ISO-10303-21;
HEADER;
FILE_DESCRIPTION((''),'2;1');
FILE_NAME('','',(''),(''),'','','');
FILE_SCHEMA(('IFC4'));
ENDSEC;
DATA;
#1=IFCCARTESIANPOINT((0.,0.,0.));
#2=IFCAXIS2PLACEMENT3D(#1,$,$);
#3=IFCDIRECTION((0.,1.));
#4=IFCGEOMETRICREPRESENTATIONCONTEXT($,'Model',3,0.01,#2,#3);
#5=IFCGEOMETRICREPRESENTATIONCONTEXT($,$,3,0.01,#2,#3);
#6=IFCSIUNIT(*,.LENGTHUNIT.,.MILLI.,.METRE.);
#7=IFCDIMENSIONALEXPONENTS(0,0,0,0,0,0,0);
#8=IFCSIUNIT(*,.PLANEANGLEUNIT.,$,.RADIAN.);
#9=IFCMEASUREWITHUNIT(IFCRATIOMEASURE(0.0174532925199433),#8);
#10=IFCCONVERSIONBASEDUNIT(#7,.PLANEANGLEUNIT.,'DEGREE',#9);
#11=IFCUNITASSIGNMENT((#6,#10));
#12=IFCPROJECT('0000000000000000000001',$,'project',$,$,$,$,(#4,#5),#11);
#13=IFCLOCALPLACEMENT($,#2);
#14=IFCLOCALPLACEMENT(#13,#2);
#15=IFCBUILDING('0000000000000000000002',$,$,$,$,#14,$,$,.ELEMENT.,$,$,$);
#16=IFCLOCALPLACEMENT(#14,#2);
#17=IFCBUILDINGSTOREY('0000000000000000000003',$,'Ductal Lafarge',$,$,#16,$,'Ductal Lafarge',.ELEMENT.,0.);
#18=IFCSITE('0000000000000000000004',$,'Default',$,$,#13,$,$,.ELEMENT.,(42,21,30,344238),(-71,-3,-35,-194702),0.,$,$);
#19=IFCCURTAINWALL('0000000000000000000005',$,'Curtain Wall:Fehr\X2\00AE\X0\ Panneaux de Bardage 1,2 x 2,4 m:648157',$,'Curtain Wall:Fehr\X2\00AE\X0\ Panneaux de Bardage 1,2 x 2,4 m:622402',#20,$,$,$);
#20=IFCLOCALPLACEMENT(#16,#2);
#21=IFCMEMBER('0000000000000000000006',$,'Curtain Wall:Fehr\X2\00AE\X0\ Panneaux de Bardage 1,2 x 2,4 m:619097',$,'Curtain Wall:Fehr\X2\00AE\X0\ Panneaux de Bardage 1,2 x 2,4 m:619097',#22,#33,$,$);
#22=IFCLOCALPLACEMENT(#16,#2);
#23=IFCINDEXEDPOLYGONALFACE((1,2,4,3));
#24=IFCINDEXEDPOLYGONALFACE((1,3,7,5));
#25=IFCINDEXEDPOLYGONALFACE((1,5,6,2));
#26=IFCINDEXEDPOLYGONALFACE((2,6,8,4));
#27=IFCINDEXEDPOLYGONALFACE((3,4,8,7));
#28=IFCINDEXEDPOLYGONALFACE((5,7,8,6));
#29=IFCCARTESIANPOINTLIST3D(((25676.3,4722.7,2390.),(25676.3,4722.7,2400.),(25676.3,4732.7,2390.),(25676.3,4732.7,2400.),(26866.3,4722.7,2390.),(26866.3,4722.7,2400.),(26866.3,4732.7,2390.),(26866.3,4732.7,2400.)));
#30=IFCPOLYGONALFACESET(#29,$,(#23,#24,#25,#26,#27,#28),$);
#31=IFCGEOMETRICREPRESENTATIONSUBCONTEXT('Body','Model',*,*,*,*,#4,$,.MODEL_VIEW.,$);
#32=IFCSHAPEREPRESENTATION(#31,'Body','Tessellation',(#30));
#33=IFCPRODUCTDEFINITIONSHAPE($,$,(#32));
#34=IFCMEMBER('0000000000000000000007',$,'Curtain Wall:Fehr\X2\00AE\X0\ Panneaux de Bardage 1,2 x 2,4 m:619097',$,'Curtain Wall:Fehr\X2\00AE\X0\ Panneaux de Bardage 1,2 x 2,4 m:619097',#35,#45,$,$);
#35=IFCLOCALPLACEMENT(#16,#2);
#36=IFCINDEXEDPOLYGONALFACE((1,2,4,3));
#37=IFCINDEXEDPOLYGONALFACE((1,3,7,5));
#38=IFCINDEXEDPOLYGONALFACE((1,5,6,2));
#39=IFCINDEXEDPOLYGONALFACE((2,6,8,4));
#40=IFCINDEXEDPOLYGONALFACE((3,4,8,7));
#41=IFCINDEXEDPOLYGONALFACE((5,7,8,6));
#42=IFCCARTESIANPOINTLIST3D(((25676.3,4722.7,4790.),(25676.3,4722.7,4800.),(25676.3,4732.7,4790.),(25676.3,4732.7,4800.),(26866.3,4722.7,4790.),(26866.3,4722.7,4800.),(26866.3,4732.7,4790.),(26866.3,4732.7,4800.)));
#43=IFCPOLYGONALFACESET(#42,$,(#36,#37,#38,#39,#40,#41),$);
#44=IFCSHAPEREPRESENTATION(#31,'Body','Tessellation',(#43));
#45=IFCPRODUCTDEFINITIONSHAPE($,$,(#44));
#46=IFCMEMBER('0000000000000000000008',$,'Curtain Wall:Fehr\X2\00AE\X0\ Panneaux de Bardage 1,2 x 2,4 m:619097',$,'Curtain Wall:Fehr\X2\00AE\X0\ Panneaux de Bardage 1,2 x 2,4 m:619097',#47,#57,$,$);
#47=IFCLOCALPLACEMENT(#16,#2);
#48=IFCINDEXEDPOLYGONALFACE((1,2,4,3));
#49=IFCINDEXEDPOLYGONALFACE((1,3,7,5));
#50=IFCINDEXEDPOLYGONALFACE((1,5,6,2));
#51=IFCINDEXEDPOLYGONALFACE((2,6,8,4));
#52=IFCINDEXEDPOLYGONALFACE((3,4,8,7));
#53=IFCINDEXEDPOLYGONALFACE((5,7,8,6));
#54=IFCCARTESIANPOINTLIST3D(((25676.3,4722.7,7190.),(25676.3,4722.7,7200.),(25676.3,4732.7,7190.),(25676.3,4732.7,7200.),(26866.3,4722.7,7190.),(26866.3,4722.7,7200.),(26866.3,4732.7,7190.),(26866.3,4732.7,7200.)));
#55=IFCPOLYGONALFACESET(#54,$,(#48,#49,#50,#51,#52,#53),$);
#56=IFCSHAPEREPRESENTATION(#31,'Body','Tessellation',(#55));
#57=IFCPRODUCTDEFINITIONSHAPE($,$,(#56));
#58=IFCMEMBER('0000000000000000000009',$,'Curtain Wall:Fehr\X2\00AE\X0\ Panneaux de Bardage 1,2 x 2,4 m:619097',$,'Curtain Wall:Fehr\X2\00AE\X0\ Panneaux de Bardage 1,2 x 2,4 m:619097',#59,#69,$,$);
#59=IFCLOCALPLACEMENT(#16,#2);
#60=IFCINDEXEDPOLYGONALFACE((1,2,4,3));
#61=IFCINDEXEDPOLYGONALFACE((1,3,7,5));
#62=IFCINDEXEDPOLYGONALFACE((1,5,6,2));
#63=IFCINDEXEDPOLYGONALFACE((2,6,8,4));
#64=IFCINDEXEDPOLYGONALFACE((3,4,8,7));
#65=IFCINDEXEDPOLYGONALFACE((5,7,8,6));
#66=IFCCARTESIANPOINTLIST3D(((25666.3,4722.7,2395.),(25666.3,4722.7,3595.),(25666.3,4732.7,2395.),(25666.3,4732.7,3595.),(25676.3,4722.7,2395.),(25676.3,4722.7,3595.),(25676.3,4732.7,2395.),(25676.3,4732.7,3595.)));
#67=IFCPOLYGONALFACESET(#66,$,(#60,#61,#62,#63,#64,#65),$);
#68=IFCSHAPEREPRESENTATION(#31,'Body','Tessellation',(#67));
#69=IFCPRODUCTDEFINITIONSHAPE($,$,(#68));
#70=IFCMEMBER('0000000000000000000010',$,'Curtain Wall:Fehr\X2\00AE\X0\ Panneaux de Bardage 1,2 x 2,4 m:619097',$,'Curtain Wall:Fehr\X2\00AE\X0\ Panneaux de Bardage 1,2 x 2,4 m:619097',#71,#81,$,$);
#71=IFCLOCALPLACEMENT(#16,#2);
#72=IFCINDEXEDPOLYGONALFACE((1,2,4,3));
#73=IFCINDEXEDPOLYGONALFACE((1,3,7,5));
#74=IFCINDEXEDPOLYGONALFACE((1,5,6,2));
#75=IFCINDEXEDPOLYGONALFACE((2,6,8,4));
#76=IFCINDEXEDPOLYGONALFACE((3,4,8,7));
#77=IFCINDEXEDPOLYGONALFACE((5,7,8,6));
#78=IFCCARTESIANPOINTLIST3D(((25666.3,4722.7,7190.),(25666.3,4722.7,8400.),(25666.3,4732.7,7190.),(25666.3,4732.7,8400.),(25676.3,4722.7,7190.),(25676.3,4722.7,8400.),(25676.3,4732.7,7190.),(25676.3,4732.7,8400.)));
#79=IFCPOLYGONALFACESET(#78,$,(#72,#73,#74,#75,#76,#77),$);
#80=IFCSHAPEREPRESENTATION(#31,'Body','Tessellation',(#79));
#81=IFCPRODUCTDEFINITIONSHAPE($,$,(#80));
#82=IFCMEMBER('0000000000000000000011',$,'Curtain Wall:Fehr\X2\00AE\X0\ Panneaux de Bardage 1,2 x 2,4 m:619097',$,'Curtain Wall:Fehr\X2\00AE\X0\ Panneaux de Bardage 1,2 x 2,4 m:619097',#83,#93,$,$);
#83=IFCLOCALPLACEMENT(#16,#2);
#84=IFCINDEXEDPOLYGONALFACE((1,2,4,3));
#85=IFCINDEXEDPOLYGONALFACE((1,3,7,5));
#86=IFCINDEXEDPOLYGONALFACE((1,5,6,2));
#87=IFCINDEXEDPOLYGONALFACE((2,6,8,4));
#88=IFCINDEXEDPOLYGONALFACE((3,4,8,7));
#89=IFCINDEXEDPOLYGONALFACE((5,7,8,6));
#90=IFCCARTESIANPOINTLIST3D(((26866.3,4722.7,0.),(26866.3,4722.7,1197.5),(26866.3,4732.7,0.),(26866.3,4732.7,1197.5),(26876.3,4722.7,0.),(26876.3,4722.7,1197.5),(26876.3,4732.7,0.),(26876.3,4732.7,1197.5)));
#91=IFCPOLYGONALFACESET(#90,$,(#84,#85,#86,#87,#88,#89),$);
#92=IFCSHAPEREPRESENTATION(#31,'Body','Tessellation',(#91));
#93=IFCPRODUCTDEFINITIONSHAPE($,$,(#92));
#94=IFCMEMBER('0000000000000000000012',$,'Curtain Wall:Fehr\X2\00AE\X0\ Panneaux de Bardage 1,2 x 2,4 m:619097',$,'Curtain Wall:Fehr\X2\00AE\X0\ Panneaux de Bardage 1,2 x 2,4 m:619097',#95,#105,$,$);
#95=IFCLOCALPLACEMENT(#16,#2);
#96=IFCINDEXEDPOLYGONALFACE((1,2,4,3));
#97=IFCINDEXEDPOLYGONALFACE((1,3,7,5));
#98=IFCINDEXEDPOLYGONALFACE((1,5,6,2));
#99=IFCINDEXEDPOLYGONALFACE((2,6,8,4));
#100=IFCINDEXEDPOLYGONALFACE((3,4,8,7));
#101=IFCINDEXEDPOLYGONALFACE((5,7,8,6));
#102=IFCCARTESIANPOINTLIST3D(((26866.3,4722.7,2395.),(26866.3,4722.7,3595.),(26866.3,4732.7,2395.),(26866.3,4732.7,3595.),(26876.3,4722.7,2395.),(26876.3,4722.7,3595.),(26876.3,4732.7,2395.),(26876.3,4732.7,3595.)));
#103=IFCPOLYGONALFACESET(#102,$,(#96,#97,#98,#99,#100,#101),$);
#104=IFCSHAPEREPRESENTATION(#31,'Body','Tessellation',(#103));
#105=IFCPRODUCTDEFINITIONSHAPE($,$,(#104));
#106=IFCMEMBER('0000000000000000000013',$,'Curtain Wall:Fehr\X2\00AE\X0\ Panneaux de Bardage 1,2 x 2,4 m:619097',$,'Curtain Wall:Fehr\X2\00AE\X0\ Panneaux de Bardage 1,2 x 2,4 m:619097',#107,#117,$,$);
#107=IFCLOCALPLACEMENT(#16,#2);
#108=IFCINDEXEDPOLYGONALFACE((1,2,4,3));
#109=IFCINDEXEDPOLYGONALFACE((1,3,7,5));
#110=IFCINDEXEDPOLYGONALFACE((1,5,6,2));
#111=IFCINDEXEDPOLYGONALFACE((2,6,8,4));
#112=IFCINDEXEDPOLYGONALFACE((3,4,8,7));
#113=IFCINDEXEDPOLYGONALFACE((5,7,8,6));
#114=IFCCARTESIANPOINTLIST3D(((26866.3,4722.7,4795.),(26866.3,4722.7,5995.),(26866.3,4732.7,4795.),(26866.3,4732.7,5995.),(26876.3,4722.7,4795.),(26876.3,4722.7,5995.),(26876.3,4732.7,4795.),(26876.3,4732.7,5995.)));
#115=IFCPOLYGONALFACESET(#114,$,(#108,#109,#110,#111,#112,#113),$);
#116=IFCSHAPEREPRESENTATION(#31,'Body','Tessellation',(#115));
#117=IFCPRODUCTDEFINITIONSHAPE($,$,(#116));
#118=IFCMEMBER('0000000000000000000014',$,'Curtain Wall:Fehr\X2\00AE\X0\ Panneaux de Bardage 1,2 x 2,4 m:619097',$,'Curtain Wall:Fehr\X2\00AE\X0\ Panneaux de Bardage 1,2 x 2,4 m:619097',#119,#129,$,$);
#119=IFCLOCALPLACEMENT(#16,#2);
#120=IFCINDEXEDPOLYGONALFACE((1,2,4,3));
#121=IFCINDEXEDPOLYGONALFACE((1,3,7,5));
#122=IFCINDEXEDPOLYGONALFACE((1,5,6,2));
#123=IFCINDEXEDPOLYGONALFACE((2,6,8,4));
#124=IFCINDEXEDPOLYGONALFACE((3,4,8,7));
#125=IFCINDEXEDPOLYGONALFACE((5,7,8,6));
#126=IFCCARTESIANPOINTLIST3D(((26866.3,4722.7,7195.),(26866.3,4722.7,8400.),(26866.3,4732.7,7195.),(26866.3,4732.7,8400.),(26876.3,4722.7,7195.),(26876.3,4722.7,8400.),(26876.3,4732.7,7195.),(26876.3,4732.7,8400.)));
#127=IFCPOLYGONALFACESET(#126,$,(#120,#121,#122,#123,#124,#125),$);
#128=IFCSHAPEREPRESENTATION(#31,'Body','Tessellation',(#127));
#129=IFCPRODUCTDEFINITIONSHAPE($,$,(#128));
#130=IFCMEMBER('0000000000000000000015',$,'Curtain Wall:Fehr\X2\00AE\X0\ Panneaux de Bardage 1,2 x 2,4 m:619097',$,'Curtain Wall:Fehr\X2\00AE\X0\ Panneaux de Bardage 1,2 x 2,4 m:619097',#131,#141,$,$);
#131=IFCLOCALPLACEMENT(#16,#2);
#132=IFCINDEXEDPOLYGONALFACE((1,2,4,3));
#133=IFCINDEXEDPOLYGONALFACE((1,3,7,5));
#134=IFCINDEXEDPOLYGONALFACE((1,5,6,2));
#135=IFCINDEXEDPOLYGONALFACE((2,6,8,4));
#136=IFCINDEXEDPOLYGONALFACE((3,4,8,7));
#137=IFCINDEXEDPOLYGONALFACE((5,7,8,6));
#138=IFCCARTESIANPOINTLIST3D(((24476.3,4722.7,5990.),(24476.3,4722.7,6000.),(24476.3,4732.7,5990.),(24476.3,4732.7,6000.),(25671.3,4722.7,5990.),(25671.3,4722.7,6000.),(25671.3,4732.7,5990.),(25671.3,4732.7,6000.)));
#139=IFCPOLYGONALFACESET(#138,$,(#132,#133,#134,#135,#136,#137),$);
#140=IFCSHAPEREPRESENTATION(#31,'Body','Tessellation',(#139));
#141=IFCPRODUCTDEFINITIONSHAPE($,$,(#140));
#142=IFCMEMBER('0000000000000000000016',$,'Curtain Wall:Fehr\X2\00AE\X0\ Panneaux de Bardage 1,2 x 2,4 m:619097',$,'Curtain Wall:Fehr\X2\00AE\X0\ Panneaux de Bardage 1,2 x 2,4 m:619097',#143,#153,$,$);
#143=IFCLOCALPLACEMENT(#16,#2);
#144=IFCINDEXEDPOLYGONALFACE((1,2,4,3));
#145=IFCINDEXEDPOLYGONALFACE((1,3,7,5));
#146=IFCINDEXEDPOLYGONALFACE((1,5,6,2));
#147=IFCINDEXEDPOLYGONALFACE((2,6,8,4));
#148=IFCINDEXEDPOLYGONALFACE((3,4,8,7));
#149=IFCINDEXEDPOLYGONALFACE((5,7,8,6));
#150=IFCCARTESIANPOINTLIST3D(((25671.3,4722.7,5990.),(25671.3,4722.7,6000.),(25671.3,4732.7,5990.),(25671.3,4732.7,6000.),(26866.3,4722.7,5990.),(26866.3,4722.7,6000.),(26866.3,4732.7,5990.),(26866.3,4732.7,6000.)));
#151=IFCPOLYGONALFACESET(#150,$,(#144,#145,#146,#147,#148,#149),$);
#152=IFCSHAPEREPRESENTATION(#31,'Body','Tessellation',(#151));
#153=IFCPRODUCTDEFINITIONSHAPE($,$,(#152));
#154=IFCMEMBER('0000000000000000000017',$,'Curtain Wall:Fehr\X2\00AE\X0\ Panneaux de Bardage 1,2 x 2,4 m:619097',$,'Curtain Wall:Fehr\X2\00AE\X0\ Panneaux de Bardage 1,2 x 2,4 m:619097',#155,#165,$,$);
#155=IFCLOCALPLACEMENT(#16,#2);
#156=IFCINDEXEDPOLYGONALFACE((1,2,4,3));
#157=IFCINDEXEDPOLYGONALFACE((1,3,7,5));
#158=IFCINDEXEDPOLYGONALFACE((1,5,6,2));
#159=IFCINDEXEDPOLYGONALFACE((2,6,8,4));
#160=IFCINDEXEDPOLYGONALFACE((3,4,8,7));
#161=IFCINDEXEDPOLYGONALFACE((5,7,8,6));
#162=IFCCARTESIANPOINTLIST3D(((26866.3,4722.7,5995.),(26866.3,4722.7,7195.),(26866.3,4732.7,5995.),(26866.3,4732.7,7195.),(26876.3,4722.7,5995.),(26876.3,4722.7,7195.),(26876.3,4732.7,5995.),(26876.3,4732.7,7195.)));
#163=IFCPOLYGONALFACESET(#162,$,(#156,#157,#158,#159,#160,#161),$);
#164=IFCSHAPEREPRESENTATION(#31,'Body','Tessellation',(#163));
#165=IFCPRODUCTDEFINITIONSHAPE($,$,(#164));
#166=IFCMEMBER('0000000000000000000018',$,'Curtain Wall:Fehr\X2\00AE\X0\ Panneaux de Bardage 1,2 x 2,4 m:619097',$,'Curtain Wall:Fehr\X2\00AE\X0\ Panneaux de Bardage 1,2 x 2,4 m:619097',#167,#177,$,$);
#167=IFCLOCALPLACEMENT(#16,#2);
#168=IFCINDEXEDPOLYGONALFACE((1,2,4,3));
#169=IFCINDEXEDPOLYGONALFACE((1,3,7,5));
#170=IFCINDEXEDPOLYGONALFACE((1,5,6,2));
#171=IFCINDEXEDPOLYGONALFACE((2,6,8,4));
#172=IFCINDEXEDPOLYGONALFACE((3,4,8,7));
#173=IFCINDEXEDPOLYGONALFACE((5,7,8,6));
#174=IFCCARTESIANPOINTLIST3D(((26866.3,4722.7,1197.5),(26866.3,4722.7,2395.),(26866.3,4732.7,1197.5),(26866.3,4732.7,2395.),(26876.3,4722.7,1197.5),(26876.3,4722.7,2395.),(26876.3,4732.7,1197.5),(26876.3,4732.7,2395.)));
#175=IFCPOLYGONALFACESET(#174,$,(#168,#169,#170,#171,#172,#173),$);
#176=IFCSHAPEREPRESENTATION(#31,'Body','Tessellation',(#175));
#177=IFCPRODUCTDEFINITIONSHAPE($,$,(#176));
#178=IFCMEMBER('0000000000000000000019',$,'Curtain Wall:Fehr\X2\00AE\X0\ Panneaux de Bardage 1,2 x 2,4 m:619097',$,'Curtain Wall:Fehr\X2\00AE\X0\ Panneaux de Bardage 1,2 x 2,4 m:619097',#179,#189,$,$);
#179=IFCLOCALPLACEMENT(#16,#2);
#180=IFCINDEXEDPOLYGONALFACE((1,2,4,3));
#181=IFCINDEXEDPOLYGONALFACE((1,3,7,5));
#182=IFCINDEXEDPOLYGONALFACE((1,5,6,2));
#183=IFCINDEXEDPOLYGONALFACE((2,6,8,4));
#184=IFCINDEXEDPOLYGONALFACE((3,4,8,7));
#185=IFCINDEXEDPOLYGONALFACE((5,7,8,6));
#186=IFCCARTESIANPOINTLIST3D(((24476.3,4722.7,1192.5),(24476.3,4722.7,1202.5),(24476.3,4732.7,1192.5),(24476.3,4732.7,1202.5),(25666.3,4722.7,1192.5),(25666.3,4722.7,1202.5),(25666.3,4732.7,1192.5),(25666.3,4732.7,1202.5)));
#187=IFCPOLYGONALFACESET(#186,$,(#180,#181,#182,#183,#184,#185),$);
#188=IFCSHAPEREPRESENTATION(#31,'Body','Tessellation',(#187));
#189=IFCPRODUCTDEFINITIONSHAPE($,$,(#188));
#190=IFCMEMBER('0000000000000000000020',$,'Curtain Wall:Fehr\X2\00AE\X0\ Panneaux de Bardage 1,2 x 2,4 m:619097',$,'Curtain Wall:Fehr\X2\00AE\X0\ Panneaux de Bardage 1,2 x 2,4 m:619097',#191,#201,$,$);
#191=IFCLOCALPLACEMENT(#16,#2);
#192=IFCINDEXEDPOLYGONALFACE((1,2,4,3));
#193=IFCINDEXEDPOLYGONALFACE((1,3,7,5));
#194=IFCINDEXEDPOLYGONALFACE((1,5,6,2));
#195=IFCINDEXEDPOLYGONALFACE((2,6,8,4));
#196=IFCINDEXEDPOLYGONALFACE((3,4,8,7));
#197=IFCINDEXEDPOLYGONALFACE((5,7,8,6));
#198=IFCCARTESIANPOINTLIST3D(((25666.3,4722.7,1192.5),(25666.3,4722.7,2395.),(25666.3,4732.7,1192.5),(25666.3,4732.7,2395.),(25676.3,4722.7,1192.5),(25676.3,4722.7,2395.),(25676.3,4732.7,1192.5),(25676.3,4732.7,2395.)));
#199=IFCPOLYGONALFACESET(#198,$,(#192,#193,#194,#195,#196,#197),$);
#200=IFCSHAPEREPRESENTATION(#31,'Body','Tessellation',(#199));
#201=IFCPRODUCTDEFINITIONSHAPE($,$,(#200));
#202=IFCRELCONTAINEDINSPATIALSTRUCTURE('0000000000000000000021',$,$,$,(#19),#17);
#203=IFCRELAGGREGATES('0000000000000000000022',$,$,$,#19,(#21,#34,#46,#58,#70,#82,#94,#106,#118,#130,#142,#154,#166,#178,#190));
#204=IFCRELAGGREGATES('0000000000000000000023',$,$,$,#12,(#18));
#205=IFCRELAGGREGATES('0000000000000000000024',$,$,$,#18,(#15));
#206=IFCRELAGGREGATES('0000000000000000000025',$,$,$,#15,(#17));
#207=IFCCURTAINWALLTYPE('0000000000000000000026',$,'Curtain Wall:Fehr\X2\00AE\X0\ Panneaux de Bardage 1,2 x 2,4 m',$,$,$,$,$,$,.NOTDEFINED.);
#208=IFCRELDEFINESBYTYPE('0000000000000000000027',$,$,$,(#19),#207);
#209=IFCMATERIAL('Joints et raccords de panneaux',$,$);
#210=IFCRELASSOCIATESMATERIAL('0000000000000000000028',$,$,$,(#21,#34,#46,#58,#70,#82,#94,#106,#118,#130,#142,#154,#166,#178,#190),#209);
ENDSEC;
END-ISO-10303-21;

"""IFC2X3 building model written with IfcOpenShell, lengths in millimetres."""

from ifc_helpers import new_model, entity, si_unit, converted_unit, direction, frame, frame_2d, origin, origin_2d_with_axis, place, context, subcontext, project, spatial, rectangle, extrude, material, type_object, element, aggregate, save


model = new_model("IFC2X3")

# Units and contexts
model_context = context("Model", 3, precision=0.01, world=origin(), true_north=direction((0.0, 1.0)))
context_of_model = context(None, 3, precision=0.01, world=origin(), true_north=direction((0.0, 1.0)))
body_context = subcontext(model_context, "Body", "Model", "MODEL_VIEW")
ifc_project = project(units=[si_unit("LENGTHUNIT", "METRE", prefix="MILLI"), converted_unit("PLANEANGLEUNIT", "DEGREE", entity("IfcRatioMeasure", 0.0174532925199433), si_unit("PLANEANGLEUNIT", "RADIAN"), dimensions=[0, 0, 0, 0, 0, 0, 0])], contexts=[model_context, context_of_model])

# Site, building, storey
site_placement = place(None, origin())
site = spatial("IfcSite", under=ifc_project, at=site_placement, Name="Default", CompositionType="ELEMENT", RefLatitude=(42, 21, 30, 344238), RefLongitude=(-71, -3, -35, -194702), RefElevation=0.0)
building_placement = place(site_placement, origin())
building = spatial("IfcBuilding", under=site, at=building_placement, CompositionType="ELEMENT")
storey_placement = place(building_placement, origin())
storey = spatial("IfcBuildingStorey", under=building, at=storey_placement, Name="Ductal Lafarge", LongName="Ductal Lafarge", CompositionType="ELEMENT", Elevation=0.0)

# Curtain wall, members
curtain_wall_type = type_object("IfcCurtainWallType", Name="Curtain Wall:Fehr® Panneaux de Bardage 1,2 x 2,4 m", PredefinedType="NOTDEFINED")
curtain_wall_placement = place(storey_placement, origin())
curtain_wall = element("IfcCurtainWall", 1, at=curtain_wall_placement, inside=storey, type_object=curtain_wall_type, Name="Curtain Wall:Fehr® Panneaux de Bardage 1,2 x 2,4 m:648157", ObjectType="Curtain Wall:Fehr® Panneaux de Bardage 1,2 x 2,4 m:622402")
ifc_material_1 = material(Name="Joints et raccords de panneaux")
member_1_placement = place(curtain_wall_placement, frame((25676.3, 4722.7, 2390.0)))
member_1 = element("IfcMember", 2, at=member_1_placement, material=ifc_material_1, Name="Curtain Wall:Fehr® Panneaux de Bardage 1,2 x 2,4 m:619097", ObjectType="Curtain Wall:Fehr® Panneaux de Bardage 1,2 x 2,4 m:619097", context=body_context, shape_type="SweptSolid", body=[
    extrude(rectangle(XDim=1190.0, YDim=10.0, at=frame_2d((0.0, 0.0), x_axis=(1.0, 0.0))), frame((595.0, 5.0, 0.0), z_axis=(0.0, 0.0, 1.0), x_axis=(-1.0, 0.0, 0.0)), (0.0, 0.0, 1.0), 10.0),
])
member_2_placement = place(curtain_wall_placement, frame((25676.3, 4722.7, 4790.0)))
member_2 = element("IfcMember", 3, at=member_2_placement, material=ifc_material_1, Name="Curtain Wall:Fehr® Panneaux de Bardage 1,2 x 2,4 m:619097", ObjectType="Curtain Wall:Fehr® Panneaux de Bardage 1,2 x 2,4 m:619097", context=body_context, shape_type="SweptSolid", body=[
    extrude(rectangle(XDim=1190.0, YDim=10.0, at=frame_2d((0.0, 0.0), x_axis=(1.0, 0.0))), frame((595.0, 5.0, 0.0), z_axis=(0.0, 0.0, 1.0), x_axis=(-1.0, 0.0, 0.0)), (0.0, 0.0, 1.0), 10.0),
])
member_3_placement = place(curtain_wall_placement, frame((25676.3, 4722.7, 7190.0)))
member_3 = element("IfcMember", 4, at=member_3_placement, material=ifc_material_1, Name="Curtain Wall:Fehr® Panneaux de Bardage 1,2 x 2,4 m:619097", ObjectType="Curtain Wall:Fehr® Panneaux de Bardage 1,2 x 2,4 m:619097", context=body_context, shape_type="SweptSolid", body=[
    extrude(rectangle(XDim=1190.0, YDim=10.0, at=frame_2d((0.0, 0.0), x_axis=(1.0, 0.0))), frame((595.0, 5.0, 0.0), z_axis=(0.0, 0.0, 1.0), x_axis=(-1.0, 0.0, 0.0)), (0.0, 0.0, 1.0), 10.0),
])
member_4_placement = place(curtain_wall_placement, frame((25666.3, 4722.7, 2395.0)))
member_4 = element("IfcMember", 5, at=member_4_placement, material=ifc_material_1, Name="Curtain Wall:Fehr® Panneaux de Bardage 1,2 x 2,4 m:619097", ObjectType="Curtain Wall:Fehr® Panneaux de Bardage 1,2 x 2,4 m:619097", context=body_context, shape_type="SweptSolid", body=[
    extrude(rectangle(XDim=10.0, YDim=10.0, at=frame_2d((0.0, 0.0), x_axis=(1.0, 0.0))), frame((5.0, 5.0, 0.0), z_axis=(0.0, 0.0, 1.0), x_axis=(0.0, 1.0, 0.0)), (0.0, 0.0, 1.0), 1200.0),
])
member_5_placement = place(curtain_wall_placement, frame((25666.3, 4722.7, 7190.0)))
member_5 = element("IfcMember", 6, at=member_5_placement, material=ifc_material_1, Name="Curtain Wall:Fehr® Panneaux de Bardage 1,2 x 2,4 m:619097", ObjectType="Curtain Wall:Fehr® Panneaux de Bardage 1,2 x 2,4 m:619097", context=body_context, shape_type="SweptSolid", body=[
    extrude(rectangle(XDim=10.0, YDim=10.0, at=origin_2d_with_axis()), frame((5.0, 5.0, 0.0), z_axis=(0.0, 0.0, 1.0), x_axis=(0.0, 1.0, 0.0)), (0.0, 0.0, 1.0), 1210.0),
])
member_6_placement = place(curtain_wall_placement, frame((26866.3, 4722.7, 0.0)))
member_6 = element("IfcMember", 7, at=member_6_placement, material=ifc_material_1, Name="Curtain Wall:Fehr® Panneaux de Bardage 1,2 x 2,4 m:619097", ObjectType="Curtain Wall:Fehr® Panneaux de Bardage 1,2 x 2,4 m:619097", context=body_context, shape_type="SweptSolid", body=[
    extrude(rectangle(XDim=10.0, YDim=10.0, at=frame_2d((0.0, 0.0), x_axis=(1.0, 0.0))), frame((5.0, 5.0, 0.0), z_axis=(0.0, 0.0, 1.0), x_axis=(0.0, 1.0, 0.0)), (0.0, 0.0, 1.0), 1197.5),
])
member_7_placement = place(curtain_wall_placement, frame((26866.3, 4722.7, 2395.0)))
member_7 = element("IfcMember", 8, at=member_7_placement, material=ifc_material_1, Name="Curtain Wall:Fehr® Panneaux de Bardage 1,2 x 2,4 m:619097", ObjectType="Curtain Wall:Fehr® Panneaux de Bardage 1,2 x 2,4 m:619097", context=body_context, shape_type="SweptSolid", body=[
    extrude(rectangle(XDim=10.0, YDim=10.0, at=frame_2d((0.0, 0.0), x_axis=(1.0, 0.0))), frame((5.0, 5.0, 0.0), z_axis=(0.0, 0.0, 1.0), x_axis=(0.0, 1.0, 0.0)), (0.0, 0.0, 1.0), 1200.0),
])
member_8_placement = place(curtain_wall_placement, frame((26866.3, 4722.7, 4795.0)))
member_8 = element("IfcMember", 9, at=member_8_placement, material=ifc_material_1, Name="Curtain Wall:Fehr® Panneaux de Bardage 1,2 x 2,4 m:619097", ObjectType="Curtain Wall:Fehr® Panneaux de Bardage 1,2 x 2,4 m:619097", context=body_context, shape_type="SweptSolid", body=[
    extrude(rectangle(XDim=10.0, YDim=10.0, at=frame_2d((0.0, 0.0), x_axis=(1.0, 0.0))), frame((5.0, 5.0, 0.0), z_axis=(0.0, 0.0, 1.0), x_axis=(0.0, 1.0, 0.0)), (0.0, 0.0, 1.0), 1200.0),
])
member_9_placement = place(curtain_wall_placement, frame((26866.3, 4722.7, 7195.0)))
member_9 = element("IfcMember", 10, at=member_9_placement, material=ifc_material_1, Name="Curtain Wall:Fehr® Panneaux de Bardage 1,2 x 2,4 m:619097", ObjectType="Curtain Wall:Fehr® Panneaux de Bardage 1,2 x 2,4 m:619097", context=body_context, shape_type="SweptSolid", body=[
    extrude(rectangle(XDim=10.0, YDim=10.0, at=origin_2d_with_axis()), frame((5.0, 5.0, 0.0), z_axis=(0.0, 0.0, 1.0), x_axis=(0.0, 1.0, 0.0)), (0.0, 0.0, 1.0), 1205.0),
])
member_10_placement = place(curtain_wall_placement, frame((24476.3, 4722.7, 5990.0)))
member_10 = element("IfcMember", 11, at=member_10_placement, material=ifc_material_1, Name="Curtain Wall:Fehr® Panneaux de Bardage 1,2 x 2,4 m:619097", ObjectType="Curtain Wall:Fehr® Panneaux de Bardage 1,2 x 2,4 m:619097", context=body_context, shape_type="SweptSolid", body=[
    extrude(rectangle(XDim=1195.0, YDim=10.0, at=frame_2d((0.0, 0.0), x_axis=(1.0, 0.0))), frame((597.5, 5.0, 0.0), z_axis=(0.0, 0.0, 1.0), x_axis=(-1.0, 0.0, 0.0)), (0.0, 0.0, 1.0), 10.0),
])
member_11_placement = place(curtain_wall_placement, frame((25671.3, 4722.7, 5990.0)))
member_11 = element("IfcMember", 12, at=member_11_placement, material=ifc_material_1, Name="Curtain Wall:Fehr® Panneaux de Bardage 1,2 x 2,4 m:619097", ObjectType="Curtain Wall:Fehr® Panneaux de Bardage 1,2 x 2,4 m:619097", context=body_context, shape_type="SweptSolid", body=[
    extrude(rectangle(XDim=1195.0, YDim=10.0, at=frame_2d((0.0, 0.0), x_axis=(1.0, 0.0))), frame((597.5, 5.0, 0.0), z_axis=(0.0, 0.0, 1.0), x_axis=(-1.0, 0.0, 0.0)), (0.0, 0.0, 1.0), 10.0),
])
member_12_placement = place(curtain_wall_placement, frame((26866.3, 4722.7, 5995.0)))
member_12 = element("IfcMember", 13, at=member_12_placement, material=ifc_material_1, Name="Curtain Wall:Fehr® Panneaux de Bardage 1,2 x 2,4 m:619097", ObjectType="Curtain Wall:Fehr® Panneaux de Bardage 1,2 x 2,4 m:619097", context=body_context, shape_type="SweptSolid", body=[
    extrude(rectangle(XDim=10.0, YDim=10.0, at=frame_2d((0.0, 0.0), x_axis=(1.0, 0.0))), frame((5.0, 5.0, 0.0), z_axis=(0.0, 0.0, 1.0), x_axis=(0.0, 1.0, 0.0)), (0.0, 0.0, 1.0), 1200.0),
])
member_13_placement = place(curtain_wall_placement, frame((26866.3, 4722.7, 1197.5)))
member_13 = element("IfcMember", 14, at=member_13_placement, material=ifc_material_1, Name="Curtain Wall:Fehr® Panneaux de Bardage 1,2 x 2,4 m:619097", ObjectType="Curtain Wall:Fehr® Panneaux de Bardage 1,2 x 2,4 m:619097", context=body_context, shape_type="SweptSolid", body=[
    extrude(rectangle(XDim=10.0, YDim=10.0, at=frame_2d((0.0, 0.0), x_axis=(1.0, 0.0))), frame((5.0, 5.0, 0.0), z_axis=(0.0, 0.0, 1.0), x_axis=(0.0, 1.0, 0.0)), (0.0, 0.0, 1.0), 1197.5),
])
member_14_placement = place(curtain_wall_placement, frame((24476.3, 4722.7, 1192.5)))
member_14 = element("IfcMember", 15, at=member_14_placement, material=ifc_material_1, Name="Curtain Wall:Fehr® Panneaux de Bardage 1,2 x 2,4 m:619097", ObjectType="Curtain Wall:Fehr® Panneaux de Bardage 1,2 x 2,4 m:619097", context=body_context, shape_type="SweptSolid", body=[
    extrude(rectangle(XDim=1190.0, YDim=10.0, at=frame_2d((0.0, 0.0), x_axis=(1.0, 0.0))), frame((595.0, 5.0, 0.0), z_axis=(0.0, 0.0, 1.0), x_axis=(-1.0, 0.0, 0.0)), (0.0, 0.0, 1.0), 10.0),
])
member_15_placement = place(curtain_wall_placement, frame((25666.3, 4722.7, 1192.5)))
member_15 = element("IfcMember", 16, at=member_15_placement, material=ifc_material_1, Name="Curtain Wall:Fehr® Panneaux de Bardage 1,2 x 2,4 m:619097", ObjectType="Curtain Wall:Fehr® Panneaux de Bardage 1,2 x 2,4 m:619097", context=body_context, shape_type="SweptSolid", body=[
    extrude(rectangle(XDim=10.0, YDim=10.0, at=frame_2d((0.0, 0.0), x_axis=(1.0, 0.0))), frame((5.0, 5.0, 0.0), z_axis=(0.0, 0.0, 1.0), x_axis=(0.0, 1.0, 0.0)), (0.0, 0.0, 1.0), 1202.5),
])
aggregate(curtain_wall, [member_1, member_2, member_3, member_4, member_5, member_6, member_7, member_8, member_9, member_10, member_11, member_12, member_13, member_14, member_15])

save(model, "model.ifc")
